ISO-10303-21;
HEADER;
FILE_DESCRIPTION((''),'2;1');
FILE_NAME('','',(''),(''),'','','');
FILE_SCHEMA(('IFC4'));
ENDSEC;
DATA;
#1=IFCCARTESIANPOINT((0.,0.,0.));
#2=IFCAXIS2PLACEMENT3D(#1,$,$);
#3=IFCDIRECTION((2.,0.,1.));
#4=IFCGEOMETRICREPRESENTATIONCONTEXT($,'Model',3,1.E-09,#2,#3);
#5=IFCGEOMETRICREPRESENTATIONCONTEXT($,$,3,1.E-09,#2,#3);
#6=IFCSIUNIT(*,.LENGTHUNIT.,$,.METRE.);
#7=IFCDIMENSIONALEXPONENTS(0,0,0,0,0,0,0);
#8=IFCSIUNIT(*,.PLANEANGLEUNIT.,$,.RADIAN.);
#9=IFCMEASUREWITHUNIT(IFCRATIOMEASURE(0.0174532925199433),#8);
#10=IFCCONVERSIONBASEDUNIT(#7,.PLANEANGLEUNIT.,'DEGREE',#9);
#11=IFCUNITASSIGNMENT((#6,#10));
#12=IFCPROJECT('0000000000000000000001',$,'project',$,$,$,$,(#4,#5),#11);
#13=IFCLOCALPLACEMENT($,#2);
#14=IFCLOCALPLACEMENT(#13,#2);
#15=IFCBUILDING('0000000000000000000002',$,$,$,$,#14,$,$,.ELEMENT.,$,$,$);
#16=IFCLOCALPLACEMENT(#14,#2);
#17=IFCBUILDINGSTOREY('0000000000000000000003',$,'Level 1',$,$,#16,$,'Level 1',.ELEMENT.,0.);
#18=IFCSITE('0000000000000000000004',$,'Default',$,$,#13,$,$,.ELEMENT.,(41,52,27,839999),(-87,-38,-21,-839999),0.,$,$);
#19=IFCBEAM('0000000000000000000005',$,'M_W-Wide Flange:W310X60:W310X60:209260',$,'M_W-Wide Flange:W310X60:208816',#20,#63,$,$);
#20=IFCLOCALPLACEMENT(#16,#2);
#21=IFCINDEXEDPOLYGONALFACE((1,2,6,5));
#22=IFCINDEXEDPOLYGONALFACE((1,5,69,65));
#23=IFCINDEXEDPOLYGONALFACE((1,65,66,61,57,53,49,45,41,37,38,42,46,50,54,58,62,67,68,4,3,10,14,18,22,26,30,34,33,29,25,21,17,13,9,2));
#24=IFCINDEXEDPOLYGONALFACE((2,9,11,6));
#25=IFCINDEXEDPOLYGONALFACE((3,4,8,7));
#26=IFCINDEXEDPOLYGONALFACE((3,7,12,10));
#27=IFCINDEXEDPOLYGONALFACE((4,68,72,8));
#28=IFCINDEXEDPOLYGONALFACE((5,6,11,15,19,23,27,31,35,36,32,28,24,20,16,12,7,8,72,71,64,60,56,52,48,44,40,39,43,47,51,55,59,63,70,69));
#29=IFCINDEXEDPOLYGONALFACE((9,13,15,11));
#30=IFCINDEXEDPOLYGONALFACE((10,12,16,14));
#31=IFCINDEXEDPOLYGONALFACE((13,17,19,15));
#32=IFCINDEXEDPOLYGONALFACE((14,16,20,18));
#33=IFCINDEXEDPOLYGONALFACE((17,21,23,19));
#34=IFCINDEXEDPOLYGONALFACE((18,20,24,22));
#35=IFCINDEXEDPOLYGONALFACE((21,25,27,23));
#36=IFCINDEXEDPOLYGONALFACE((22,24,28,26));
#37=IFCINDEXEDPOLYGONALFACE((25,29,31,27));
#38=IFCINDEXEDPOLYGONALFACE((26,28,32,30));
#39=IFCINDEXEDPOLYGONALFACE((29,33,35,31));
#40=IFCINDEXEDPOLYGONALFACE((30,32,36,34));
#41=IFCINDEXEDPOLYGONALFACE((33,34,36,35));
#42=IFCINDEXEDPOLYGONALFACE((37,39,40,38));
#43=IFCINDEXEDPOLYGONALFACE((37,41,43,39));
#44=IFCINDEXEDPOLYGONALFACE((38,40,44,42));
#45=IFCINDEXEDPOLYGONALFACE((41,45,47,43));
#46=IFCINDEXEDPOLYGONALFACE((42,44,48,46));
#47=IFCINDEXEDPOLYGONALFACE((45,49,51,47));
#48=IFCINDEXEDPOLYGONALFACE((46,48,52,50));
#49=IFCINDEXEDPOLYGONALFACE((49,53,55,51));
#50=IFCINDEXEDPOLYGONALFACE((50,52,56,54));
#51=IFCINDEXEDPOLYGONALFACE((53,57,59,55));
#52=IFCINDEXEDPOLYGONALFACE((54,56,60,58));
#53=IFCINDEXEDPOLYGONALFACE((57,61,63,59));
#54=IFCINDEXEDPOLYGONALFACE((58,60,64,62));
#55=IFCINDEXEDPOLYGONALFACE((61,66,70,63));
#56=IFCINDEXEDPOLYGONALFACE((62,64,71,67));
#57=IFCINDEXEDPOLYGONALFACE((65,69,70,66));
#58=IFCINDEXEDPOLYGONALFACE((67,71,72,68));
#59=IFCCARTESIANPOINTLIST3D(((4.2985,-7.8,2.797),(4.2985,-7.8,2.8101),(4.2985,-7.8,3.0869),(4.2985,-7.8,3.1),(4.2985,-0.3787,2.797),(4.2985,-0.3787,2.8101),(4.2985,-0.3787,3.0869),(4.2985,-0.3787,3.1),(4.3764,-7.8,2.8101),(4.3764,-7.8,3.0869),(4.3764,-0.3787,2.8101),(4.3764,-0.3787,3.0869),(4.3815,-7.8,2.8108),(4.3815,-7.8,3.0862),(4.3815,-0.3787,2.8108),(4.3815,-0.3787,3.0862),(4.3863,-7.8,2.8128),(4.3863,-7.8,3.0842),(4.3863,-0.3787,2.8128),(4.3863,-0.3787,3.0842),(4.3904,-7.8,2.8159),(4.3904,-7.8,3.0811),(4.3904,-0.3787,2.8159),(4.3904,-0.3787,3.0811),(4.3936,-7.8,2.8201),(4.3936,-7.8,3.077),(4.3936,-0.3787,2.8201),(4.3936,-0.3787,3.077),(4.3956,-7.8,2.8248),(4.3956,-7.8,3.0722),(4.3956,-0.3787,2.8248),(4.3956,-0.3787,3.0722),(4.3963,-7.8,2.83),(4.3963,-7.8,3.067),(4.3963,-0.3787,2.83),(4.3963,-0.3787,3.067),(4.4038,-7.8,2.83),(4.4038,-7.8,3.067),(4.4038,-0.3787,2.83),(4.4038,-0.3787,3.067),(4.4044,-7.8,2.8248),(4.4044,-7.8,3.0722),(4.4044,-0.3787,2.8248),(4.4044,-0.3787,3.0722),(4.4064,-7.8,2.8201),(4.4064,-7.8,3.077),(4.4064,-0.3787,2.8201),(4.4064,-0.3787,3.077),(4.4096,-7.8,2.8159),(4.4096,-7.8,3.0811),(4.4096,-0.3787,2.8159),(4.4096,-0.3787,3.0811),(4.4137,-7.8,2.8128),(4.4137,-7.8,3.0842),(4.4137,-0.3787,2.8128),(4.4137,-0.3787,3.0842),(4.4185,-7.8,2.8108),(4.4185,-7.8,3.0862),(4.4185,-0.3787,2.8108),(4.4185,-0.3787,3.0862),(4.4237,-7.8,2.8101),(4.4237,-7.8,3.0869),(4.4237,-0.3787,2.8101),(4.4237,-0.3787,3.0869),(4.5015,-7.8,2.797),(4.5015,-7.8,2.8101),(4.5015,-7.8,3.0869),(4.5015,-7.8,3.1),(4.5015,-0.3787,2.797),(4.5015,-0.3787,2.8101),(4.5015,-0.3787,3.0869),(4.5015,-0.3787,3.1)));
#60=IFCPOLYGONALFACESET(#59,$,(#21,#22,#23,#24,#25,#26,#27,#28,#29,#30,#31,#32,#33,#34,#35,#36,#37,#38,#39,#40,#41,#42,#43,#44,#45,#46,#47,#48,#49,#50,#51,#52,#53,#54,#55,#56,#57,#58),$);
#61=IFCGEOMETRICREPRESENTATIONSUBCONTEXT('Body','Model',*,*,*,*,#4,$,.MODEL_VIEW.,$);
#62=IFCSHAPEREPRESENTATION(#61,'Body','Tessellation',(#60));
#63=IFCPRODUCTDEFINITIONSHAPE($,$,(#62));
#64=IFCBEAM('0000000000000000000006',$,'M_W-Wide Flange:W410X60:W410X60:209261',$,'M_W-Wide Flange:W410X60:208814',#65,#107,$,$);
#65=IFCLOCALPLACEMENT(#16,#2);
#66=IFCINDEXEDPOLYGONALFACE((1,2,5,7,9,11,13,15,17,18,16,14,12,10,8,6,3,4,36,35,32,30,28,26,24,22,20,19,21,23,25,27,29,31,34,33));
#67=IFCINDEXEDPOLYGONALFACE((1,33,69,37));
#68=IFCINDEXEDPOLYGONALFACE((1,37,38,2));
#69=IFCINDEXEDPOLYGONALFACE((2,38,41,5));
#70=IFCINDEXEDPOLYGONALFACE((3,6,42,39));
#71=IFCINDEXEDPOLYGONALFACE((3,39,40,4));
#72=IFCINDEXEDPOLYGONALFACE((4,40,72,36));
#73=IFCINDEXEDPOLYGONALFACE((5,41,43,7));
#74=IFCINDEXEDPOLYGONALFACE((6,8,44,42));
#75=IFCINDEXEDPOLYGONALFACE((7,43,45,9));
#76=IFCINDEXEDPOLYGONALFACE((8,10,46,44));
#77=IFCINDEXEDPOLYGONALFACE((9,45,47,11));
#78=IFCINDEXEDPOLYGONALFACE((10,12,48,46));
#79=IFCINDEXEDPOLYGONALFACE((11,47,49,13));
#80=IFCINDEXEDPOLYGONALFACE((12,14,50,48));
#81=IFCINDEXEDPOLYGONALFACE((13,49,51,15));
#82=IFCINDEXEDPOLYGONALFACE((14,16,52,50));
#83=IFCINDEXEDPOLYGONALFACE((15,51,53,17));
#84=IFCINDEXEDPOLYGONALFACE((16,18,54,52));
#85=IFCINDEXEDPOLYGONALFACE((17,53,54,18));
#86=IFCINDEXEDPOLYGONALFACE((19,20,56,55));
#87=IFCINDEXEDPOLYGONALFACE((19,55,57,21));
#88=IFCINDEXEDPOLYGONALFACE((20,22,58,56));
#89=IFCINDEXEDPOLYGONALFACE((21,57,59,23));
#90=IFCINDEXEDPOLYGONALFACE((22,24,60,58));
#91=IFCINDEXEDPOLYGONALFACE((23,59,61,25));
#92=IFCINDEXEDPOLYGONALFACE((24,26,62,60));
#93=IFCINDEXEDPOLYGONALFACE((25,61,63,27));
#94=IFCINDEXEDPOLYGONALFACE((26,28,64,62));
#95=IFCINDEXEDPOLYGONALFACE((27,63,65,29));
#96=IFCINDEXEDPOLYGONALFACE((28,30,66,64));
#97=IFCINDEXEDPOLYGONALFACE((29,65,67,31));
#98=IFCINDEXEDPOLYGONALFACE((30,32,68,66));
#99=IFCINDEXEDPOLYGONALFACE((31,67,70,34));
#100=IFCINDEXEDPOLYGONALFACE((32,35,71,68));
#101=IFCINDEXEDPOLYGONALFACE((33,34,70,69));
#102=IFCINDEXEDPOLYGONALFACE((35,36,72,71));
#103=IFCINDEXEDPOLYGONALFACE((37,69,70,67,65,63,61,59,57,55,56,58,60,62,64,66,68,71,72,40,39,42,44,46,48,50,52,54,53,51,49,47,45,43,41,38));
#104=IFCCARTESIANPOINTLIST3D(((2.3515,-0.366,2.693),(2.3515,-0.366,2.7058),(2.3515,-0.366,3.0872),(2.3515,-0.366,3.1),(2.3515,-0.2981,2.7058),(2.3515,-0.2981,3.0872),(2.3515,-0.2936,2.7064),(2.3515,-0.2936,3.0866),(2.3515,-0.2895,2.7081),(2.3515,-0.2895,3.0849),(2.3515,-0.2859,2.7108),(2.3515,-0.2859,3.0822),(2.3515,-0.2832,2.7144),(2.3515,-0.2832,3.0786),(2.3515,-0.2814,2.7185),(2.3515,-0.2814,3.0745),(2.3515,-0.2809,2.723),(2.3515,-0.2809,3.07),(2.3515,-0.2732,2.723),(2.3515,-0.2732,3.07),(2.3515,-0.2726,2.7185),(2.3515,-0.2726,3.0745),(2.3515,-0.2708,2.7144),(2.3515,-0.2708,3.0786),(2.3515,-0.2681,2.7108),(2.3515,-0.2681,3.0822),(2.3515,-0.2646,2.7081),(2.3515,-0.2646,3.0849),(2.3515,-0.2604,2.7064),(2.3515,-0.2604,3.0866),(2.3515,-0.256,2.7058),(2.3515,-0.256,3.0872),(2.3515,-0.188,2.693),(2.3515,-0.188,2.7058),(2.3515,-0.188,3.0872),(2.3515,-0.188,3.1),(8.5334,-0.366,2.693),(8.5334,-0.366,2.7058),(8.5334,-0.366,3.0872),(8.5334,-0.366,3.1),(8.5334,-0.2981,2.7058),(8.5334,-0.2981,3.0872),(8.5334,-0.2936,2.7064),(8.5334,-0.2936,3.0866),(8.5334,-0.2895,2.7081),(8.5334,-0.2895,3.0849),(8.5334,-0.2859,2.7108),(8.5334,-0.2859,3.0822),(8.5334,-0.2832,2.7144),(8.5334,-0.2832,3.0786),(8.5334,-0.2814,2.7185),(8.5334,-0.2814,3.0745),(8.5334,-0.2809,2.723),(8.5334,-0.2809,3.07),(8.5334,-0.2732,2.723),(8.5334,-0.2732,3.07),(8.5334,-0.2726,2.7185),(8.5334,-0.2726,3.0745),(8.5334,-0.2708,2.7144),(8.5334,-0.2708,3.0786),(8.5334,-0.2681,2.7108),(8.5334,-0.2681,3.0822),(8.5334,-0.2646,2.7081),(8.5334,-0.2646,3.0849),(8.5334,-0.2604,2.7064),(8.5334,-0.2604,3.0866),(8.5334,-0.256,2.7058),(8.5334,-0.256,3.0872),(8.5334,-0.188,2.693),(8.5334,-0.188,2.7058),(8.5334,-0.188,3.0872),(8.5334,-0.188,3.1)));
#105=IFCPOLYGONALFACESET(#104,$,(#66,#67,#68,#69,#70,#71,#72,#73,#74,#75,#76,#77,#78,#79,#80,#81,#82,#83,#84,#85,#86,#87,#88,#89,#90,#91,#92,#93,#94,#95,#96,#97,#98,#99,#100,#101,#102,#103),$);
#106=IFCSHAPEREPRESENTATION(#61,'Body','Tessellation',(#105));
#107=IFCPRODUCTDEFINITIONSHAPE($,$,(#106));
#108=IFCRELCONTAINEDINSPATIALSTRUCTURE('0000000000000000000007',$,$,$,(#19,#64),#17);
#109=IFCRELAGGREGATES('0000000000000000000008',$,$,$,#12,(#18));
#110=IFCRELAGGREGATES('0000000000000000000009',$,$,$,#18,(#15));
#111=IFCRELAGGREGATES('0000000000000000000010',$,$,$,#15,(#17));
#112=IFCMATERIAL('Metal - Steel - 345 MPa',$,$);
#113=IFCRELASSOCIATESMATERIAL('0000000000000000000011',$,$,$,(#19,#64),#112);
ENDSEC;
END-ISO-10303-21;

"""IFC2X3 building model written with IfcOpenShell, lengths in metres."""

from ifc_helpers import new_model, entity, si_unit, converted_unit, direction, frame, frame_2d, origin, place, context, subcontext, project, spatial, i_section, extrude, material, element, save


model = new_model("IFC2X3")

# Units and contexts
model_context = context("Model", 3, precision=1e-09, world=origin(), true_north=direction((2.0, 0.0, 1.0)))
context_of_model = context(None, 3, precision=1e-09, world=origin(), true_north=direction((2.0, 0.0, 1.0)))
body_context = subcontext(model_context, "Body", "Model", "MODEL_VIEW")
ifc_project = project(units=[si_unit("LENGTHUNIT", "METRE"), converted_unit("PLANEANGLEUNIT", "DEGREE", entity("IfcRatioMeasure", 0.0174532925199433), si_unit("PLANEANGLEUNIT", "RADIAN"), dimensions=[0, 0, 0, 0, 0, 0, 0])], contexts=[model_context, context_of_model])

# Site, building, storey
site_placement = place(None, origin())
site = spatial("IfcSite", under=ifc_project, at=site_placement, Name="Default", CompositionType="ELEMENT", RefLatitude=(41, 52, 27, 839999), RefLongitude=(-87, -38, -21, -839999), RefElevation=0.0)
building_placement = place(site_placement, origin())
building = spatial("IfcBuilding", under=site, at=building_placement, CompositionType="ELEMENT")
storey_placement = place(building_placement, origin())
storey = spatial("IfcBuildingStorey", under=building, at=storey_placement, Name="Level 1", LongName="Level 1", CompositionType="ELEMENT", Elevation=0.0)

# Beams
ifc_material_1 = material(Name="Metal - Steel - 345 MPa")
beam_1_placement = place(storey_placement, frame((4.4, -7.8, 3.1), z_axis=(0.0, 0.0, 1.0), x_axis=(0.0, 1.0, 0.0)))
element("IfcBeam", 1, at=beam_1_placement, inside=storey, material=ifc_material_1, Name="M_W-Wide Flange:W310X60:W310X60:209260", ObjectType="M_W-Wide Flange:W310X60:208816", context=body_context, shape_type="SweptSolid", body=[
    extrude(i_section(OverallWidth=0.203, OverallDepth=0.303, WebThickness=0.0075, FlangeThickness=0.0131, FilletRadius=0.0199, at=frame_2d((0.0, 0.0), x_axis=(1.0, 0.0))), frame((0.0, 0.0, -0.1515), z_axis=(-1.0, 0.0, 0.0), x_axis=(0.0, -1.0, 0.0)), (0.0, 0.0, -1.0), 7.4213),
])
beam_2_placement = place(storey_placement, frame((8.5915, -0.277, 3.1), z_axis=(0.0, 0.0, 1.0), x_axis=(-1.0, 0.0, 0.0)))
element("IfcBeam", 2, at=beam_2_placement, inside=storey, material=ifc_material_1, Name="M_W-Wide Flange:W410X60:W410X60:209261", ObjectType="M_W-Wide Flange:W410X60:208814", context=body_context, shape_type="SweptSolid", body=[
    extrude(i_section(OverallWidth=0.178, OverallDepth=0.407, WebThickness=0.0077, FlangeThickness=0.0128, FilletRadius=0.0172, at=frame_2d((0.0, 0.0), x_axis=(1.0, 0.0))), frame((0.0581, 0.0, -0.2035), z_axis=(-1.0, 0.0, 0.0), x_axis=(0.0, -1.0, 0.0)), (0.0, 0.0, -1.0), 6.1819),
])

save(model, "model.ifc")
